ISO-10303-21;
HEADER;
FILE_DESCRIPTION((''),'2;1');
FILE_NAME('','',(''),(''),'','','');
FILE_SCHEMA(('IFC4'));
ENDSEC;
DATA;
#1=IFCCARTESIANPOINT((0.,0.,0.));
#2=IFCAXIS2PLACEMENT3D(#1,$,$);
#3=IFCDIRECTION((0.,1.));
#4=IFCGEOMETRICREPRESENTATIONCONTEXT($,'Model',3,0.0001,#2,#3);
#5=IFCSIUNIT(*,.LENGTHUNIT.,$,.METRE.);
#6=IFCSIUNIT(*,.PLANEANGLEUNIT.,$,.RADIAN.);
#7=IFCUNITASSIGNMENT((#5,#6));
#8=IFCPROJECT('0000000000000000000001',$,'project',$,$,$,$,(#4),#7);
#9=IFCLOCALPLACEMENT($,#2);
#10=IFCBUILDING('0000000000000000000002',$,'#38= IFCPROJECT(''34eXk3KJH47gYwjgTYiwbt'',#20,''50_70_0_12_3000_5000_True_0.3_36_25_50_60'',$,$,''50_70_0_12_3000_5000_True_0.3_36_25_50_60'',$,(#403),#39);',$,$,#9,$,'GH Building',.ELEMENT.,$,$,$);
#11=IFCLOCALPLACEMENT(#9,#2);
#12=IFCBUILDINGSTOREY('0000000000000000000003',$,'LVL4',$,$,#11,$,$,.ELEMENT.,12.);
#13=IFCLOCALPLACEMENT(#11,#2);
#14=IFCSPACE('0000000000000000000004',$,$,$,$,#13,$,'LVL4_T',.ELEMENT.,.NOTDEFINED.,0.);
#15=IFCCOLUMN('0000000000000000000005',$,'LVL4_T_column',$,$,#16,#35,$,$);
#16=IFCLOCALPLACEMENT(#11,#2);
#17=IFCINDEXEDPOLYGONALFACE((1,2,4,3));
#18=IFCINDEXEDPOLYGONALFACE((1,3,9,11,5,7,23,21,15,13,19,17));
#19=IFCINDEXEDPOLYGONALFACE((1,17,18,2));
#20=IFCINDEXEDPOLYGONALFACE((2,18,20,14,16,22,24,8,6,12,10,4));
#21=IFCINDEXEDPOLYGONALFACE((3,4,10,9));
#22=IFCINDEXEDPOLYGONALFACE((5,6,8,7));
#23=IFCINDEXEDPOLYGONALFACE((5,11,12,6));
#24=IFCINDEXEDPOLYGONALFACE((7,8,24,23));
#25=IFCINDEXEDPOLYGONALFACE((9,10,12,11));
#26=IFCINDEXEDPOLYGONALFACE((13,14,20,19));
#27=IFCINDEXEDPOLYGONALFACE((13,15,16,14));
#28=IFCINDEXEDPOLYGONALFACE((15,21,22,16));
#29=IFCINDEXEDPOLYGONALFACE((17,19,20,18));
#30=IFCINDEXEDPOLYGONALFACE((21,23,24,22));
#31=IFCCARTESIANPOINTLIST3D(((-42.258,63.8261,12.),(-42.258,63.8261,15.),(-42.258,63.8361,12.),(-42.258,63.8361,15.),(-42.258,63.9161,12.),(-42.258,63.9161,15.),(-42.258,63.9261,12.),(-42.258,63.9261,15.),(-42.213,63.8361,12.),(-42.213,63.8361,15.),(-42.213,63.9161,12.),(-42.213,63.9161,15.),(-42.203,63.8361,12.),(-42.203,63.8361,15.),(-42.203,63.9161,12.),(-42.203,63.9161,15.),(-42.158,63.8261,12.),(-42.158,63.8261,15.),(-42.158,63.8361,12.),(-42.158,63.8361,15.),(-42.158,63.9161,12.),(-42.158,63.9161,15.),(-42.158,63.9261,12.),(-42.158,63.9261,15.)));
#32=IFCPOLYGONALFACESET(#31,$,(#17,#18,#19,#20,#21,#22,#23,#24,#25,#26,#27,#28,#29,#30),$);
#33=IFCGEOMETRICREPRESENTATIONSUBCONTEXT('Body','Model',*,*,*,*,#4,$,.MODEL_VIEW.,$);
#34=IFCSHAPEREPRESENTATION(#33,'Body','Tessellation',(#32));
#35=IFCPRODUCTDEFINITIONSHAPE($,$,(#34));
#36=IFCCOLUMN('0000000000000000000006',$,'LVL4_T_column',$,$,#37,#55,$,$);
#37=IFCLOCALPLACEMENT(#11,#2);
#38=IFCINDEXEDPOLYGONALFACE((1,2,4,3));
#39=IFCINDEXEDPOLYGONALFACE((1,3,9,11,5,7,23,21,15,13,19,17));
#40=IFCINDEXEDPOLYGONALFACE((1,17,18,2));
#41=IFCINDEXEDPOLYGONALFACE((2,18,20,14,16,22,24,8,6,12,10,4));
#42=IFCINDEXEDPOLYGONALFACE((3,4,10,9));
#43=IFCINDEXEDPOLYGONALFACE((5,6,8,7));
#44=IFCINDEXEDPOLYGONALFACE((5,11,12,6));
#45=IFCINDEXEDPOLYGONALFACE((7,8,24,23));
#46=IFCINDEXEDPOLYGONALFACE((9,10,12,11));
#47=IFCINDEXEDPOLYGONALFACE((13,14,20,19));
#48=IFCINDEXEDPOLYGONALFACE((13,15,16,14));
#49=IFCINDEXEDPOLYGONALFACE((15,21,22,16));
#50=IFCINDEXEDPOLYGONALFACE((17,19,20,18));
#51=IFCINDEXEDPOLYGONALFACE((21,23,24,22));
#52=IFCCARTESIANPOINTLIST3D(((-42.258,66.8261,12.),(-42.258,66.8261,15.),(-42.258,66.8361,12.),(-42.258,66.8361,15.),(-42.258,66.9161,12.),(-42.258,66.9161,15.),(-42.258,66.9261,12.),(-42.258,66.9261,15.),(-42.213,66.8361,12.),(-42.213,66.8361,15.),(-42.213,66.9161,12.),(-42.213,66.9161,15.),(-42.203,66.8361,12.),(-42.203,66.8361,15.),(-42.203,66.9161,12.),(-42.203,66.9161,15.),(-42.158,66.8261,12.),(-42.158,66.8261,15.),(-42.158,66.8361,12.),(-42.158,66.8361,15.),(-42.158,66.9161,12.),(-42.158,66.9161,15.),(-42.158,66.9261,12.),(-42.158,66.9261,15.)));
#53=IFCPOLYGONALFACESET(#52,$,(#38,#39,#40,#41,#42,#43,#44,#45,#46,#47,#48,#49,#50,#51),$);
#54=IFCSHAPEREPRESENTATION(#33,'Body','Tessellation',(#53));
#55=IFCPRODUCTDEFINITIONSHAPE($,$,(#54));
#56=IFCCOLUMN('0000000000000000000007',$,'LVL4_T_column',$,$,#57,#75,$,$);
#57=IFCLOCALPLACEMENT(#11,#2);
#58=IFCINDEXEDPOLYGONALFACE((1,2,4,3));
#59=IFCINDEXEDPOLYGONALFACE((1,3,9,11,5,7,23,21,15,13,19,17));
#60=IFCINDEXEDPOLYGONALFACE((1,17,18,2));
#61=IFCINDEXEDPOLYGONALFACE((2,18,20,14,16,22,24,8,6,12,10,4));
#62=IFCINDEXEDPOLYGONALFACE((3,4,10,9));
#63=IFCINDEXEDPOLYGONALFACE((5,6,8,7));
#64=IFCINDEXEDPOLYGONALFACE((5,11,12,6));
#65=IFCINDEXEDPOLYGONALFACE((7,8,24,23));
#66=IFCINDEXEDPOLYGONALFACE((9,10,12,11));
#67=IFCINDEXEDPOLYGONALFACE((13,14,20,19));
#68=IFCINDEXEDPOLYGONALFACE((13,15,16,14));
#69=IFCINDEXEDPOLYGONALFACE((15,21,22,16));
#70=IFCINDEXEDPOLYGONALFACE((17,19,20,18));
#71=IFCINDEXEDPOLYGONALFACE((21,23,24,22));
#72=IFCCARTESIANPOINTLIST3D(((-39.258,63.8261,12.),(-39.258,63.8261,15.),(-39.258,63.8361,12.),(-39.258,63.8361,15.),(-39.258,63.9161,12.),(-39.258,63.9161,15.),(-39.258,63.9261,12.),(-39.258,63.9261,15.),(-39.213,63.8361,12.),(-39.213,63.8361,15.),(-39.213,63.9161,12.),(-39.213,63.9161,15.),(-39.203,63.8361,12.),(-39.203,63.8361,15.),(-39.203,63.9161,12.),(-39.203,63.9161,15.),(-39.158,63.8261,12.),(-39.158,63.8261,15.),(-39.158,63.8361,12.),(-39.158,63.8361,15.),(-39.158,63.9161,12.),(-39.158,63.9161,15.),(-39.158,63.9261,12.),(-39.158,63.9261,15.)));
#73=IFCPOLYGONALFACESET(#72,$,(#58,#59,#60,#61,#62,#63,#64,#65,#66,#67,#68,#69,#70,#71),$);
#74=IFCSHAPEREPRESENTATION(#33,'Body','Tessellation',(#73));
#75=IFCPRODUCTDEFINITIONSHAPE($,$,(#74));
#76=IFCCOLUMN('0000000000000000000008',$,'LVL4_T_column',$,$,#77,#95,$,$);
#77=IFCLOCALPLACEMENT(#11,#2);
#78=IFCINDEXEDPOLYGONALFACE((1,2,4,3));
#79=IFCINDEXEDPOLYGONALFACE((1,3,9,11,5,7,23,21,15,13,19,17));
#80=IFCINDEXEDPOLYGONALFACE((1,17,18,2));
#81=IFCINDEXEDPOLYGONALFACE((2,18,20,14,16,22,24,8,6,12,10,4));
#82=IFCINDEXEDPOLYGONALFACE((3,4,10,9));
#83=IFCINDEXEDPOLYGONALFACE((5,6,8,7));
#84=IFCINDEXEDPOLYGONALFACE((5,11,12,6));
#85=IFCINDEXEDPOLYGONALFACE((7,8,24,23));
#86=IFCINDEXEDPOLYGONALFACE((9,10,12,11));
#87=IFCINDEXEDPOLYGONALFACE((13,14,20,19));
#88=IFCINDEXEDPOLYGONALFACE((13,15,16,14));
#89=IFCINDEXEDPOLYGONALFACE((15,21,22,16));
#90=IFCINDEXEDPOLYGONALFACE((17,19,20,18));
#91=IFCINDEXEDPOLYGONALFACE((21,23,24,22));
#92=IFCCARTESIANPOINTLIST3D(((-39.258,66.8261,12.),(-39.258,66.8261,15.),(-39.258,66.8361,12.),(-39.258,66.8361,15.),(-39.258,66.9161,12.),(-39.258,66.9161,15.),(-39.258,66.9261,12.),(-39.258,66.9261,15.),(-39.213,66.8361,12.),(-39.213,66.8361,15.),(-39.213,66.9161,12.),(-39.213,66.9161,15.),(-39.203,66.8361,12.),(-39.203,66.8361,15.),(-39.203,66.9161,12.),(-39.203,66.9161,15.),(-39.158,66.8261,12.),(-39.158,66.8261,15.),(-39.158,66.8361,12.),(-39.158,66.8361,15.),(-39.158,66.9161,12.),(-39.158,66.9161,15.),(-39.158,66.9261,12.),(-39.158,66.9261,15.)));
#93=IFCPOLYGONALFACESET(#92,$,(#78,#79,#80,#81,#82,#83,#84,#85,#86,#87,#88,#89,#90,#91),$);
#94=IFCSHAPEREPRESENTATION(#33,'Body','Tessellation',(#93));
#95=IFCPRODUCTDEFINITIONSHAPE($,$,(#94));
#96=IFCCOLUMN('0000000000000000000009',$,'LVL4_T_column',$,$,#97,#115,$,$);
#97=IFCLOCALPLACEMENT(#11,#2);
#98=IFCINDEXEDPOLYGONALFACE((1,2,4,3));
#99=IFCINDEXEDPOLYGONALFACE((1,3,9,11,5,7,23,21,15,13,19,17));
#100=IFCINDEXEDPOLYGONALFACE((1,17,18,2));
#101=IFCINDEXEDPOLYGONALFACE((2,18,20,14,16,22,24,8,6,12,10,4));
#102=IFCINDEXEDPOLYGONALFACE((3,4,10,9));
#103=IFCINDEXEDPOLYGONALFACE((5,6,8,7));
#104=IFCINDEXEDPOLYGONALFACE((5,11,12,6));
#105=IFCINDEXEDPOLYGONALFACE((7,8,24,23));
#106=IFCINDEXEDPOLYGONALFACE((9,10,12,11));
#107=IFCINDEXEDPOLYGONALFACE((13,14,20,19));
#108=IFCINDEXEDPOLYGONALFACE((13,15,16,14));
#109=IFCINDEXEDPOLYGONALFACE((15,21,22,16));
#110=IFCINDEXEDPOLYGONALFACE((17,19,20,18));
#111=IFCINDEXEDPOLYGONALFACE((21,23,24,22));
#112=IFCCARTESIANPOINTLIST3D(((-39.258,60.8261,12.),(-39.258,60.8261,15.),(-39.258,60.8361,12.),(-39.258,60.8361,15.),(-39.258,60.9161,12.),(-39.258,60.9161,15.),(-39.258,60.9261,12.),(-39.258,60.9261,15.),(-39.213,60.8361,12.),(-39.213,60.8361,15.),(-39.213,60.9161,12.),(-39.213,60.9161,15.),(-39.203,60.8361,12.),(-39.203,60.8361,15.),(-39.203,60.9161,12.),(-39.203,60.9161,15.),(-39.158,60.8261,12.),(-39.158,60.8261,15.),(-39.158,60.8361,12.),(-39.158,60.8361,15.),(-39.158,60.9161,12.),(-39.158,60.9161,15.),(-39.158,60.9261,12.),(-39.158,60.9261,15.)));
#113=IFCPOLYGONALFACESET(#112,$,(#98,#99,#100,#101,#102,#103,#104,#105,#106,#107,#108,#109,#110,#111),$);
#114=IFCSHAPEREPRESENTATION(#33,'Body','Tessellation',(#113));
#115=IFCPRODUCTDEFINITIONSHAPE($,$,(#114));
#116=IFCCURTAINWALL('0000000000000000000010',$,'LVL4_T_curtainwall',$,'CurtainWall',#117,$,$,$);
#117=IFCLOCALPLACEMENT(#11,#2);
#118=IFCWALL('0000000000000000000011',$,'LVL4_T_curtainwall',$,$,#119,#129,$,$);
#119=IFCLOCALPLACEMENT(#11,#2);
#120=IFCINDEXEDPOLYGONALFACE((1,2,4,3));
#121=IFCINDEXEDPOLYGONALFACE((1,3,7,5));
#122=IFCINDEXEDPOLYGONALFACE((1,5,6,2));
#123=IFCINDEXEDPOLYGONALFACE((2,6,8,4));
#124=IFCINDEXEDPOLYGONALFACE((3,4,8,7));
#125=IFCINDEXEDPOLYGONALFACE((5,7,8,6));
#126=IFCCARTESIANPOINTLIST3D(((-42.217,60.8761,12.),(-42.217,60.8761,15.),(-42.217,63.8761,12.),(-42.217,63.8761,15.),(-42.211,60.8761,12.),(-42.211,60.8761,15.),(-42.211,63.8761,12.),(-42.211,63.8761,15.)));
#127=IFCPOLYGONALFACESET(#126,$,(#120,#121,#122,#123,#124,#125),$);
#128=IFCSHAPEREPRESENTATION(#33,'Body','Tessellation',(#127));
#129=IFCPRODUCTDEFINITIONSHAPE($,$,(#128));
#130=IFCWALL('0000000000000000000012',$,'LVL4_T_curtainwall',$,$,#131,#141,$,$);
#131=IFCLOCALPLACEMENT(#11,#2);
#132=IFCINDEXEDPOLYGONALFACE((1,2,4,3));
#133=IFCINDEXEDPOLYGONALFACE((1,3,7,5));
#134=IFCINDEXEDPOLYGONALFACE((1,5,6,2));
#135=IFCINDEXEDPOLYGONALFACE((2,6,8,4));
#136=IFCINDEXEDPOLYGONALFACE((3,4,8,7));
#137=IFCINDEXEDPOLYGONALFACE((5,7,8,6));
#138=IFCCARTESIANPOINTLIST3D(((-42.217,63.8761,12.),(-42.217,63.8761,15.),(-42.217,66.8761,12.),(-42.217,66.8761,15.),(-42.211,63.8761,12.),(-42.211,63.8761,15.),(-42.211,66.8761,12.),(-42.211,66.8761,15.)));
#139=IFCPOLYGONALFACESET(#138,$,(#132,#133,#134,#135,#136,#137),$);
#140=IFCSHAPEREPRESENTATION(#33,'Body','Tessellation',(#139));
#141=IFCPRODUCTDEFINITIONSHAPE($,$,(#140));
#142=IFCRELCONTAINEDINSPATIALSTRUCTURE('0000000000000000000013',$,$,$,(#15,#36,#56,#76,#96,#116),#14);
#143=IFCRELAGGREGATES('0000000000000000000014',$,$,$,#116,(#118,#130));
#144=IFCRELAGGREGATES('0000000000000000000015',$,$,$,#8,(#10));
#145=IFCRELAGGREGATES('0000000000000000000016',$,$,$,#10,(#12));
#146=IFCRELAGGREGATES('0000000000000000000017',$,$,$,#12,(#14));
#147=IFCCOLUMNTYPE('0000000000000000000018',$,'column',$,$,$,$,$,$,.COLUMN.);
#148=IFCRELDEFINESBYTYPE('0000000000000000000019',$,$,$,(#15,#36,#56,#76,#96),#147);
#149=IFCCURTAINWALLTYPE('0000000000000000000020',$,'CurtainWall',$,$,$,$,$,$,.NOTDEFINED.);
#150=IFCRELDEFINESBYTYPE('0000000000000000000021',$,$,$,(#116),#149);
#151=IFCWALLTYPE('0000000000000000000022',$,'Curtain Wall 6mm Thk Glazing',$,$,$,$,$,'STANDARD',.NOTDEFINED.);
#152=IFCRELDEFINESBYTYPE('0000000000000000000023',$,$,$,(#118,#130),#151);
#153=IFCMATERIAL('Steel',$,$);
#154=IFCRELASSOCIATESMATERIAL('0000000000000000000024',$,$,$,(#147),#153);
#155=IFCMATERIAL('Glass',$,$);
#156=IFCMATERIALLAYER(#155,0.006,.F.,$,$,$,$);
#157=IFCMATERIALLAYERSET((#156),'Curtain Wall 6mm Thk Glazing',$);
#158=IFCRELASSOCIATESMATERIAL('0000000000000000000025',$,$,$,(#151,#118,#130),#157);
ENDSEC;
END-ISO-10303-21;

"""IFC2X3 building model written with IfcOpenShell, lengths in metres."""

from ifc_helpers import new_model, si_unit, direction, frame, frame_2d, origin, origin_2d, place, context, subcontext, project, spatial, rectangle, i_section, extrude, material, layer, layer_set, layer_usage, type_object, element, aggregate, save


model = new_model("IFC2X3")

# Units and contexts
model_context = context("Model", 3, precision=0.0001, world=origin(), true_north=direction((0.0, 1.0)))
body_context = subcontext(model_context, "Body", "Model", "MODEL_VIEW")
ifc_project = project(units=[si_unit("LENGTHUNIT", "METRE"), si_unit("PLANEANGLEUNIT", "RADIAN")], contexts=[model_context])

# Building, storey, space
building_placement = place(None, origin())
building = spatial("IfcBuilding", under=ifc_project, at=building_placement, Name="#38= IFCPROJECT('34eXk3KJH47gYwjgTYiwbt',#20,'50_70_0_12_3000_5000_True_0.3_36_25_50_60',$,$,'50_70_0_12_3000_5000_True_0.3_36_25_50_60',$,(#403),#39);", LongName="GH Building", CompositionType="ELEMENT")
storey_placement = place(building_placement, origin())
storey = spatial("IfcBuildingStorey", under=building, at=storey_placement, Name="LVL4", CompositionType="ELEMENT", Elevation=12.0)
space_placement = place(storey_placement, origin())
space = spatial("IfcSpace", under=storey, at=space_placement, LongName="LVL4_T", CompositionType="ELEMENT", InteriorOrExteriorSpace="NOTDEFINED", ElevationWithFlooring=0.0)

# Columns
ifc_material_1 = material(Name="Steel")
column_type = type_object("IfcColumnType", Name="column", PredefinedType="COLUMN", material=ifc_material_1)
for number, where, name in (
    (1, (-42.208, 63.8761, 12.0), "LVL4_T_column"),
    (2, (-42.208, 66.8761, 12.0), "LVL4_T_column"),
    (3, (-39.208, 63.8761, 12.0), "LVL4_T_column"),
    (4, (-39.208, 66.8761, 12.0), "LVL4_T_column"),
    (5, (-39.208, 60.8761, 12.0), "LVL4_T_column"),
):
    element("IfcColumn", number, at=place(space_placement, frame(where)), inside=space, type_object=column_type, Name=name, context=body_context, shape_type="SweptSolid", body=[
        extrude(i_section(OverallWidth=0.1, OverallDepth=0.1, WebThickness=0.01, FlangeThickness=0.01, at=origin_2d()), origin(), (0.0, 0.0, 1.0), 3.0),
    ])

# Curtain wall, walls
curtain_wall_type = type_object("IfcCurtainWallType", Name="CurtainWall", PredefinedType="NOTDEFINED")
curtain_wall_placement = place(None, origin())
curtain_wall = element("IfcCurtainWall", 6, at=curtain_wall_placement, inside=space, type_object=curtain_wall_type, Name="LVL4_T_curtainwall", ObjectType="CurtainWall")
ifc_material_2 = material(Name="Glass")
ifc_layer = layer(ifc_material_2, 0.006, ventilated=False)
ifc_layer_set = layer_set([ifc_layer], Name="Curtain Wall 6mm Thk Glazing")
ifc_layer_usage_1 = layer_usage(ifc_layer_set, "AXIS2", "NEGATIVE", -0.003)
wall_type = type_object("IfcWallType", Name="Curtain Wall 6mm Thk Glazing", ElementType="STANDARD", PredefinedType="NOTDEFINED", material=ifc_layer_set)
wall_1_placement = place(curtain_wall_placement, frame((-42.208, 63.8761, 12.0), z_axis=(0.0, 0.0, 1.0), x_axis=(0.0, -1.0, 0.0)))
wall_1 = element("IfcWall", 7, at=wall_1_placement, type_object=wall_type, material=ifc_layer_usage_1, Name="LVL4_T_curtainwall", context=body_context, shape_type="SweptSolid", body=[
    extrude(rectangle(XDim=3.0, YDim=0.006, at=frame_2d((1.5, -0.006))), origin(), (0.0, 0.0, 1.0), 3.0),
])
ifc_layer_usage_2 = layer_usage(ifc_layer_set, "AXIS2", "NEGATIVE", -0.003)
wall_2_placement = place(curtain_wall_placement, frame((-42.208, 66.8761, 12.0), z_axis=(0.0, 0.0, 1.0), x_axis=(0.0, -1.0, 0.0)))
wall_2 = element("IfcWall", 8, at=wall_2_placement, type_object=wall_type, material=ifc_layer_usage_2, Name="LVL4_T_curtainwall", context=body_context, shape_type="SweptSolid", body=[
    extrude(rectangle(XDim=3.0, YDim=0.006, at=frame_2d((1.5, -0.006))), origin(), (0.0, 0.0, 1.0), 3.0),
])
aggregate(curtain_wall, [wall_1, wall_2])

save(model, "model.ifc")
